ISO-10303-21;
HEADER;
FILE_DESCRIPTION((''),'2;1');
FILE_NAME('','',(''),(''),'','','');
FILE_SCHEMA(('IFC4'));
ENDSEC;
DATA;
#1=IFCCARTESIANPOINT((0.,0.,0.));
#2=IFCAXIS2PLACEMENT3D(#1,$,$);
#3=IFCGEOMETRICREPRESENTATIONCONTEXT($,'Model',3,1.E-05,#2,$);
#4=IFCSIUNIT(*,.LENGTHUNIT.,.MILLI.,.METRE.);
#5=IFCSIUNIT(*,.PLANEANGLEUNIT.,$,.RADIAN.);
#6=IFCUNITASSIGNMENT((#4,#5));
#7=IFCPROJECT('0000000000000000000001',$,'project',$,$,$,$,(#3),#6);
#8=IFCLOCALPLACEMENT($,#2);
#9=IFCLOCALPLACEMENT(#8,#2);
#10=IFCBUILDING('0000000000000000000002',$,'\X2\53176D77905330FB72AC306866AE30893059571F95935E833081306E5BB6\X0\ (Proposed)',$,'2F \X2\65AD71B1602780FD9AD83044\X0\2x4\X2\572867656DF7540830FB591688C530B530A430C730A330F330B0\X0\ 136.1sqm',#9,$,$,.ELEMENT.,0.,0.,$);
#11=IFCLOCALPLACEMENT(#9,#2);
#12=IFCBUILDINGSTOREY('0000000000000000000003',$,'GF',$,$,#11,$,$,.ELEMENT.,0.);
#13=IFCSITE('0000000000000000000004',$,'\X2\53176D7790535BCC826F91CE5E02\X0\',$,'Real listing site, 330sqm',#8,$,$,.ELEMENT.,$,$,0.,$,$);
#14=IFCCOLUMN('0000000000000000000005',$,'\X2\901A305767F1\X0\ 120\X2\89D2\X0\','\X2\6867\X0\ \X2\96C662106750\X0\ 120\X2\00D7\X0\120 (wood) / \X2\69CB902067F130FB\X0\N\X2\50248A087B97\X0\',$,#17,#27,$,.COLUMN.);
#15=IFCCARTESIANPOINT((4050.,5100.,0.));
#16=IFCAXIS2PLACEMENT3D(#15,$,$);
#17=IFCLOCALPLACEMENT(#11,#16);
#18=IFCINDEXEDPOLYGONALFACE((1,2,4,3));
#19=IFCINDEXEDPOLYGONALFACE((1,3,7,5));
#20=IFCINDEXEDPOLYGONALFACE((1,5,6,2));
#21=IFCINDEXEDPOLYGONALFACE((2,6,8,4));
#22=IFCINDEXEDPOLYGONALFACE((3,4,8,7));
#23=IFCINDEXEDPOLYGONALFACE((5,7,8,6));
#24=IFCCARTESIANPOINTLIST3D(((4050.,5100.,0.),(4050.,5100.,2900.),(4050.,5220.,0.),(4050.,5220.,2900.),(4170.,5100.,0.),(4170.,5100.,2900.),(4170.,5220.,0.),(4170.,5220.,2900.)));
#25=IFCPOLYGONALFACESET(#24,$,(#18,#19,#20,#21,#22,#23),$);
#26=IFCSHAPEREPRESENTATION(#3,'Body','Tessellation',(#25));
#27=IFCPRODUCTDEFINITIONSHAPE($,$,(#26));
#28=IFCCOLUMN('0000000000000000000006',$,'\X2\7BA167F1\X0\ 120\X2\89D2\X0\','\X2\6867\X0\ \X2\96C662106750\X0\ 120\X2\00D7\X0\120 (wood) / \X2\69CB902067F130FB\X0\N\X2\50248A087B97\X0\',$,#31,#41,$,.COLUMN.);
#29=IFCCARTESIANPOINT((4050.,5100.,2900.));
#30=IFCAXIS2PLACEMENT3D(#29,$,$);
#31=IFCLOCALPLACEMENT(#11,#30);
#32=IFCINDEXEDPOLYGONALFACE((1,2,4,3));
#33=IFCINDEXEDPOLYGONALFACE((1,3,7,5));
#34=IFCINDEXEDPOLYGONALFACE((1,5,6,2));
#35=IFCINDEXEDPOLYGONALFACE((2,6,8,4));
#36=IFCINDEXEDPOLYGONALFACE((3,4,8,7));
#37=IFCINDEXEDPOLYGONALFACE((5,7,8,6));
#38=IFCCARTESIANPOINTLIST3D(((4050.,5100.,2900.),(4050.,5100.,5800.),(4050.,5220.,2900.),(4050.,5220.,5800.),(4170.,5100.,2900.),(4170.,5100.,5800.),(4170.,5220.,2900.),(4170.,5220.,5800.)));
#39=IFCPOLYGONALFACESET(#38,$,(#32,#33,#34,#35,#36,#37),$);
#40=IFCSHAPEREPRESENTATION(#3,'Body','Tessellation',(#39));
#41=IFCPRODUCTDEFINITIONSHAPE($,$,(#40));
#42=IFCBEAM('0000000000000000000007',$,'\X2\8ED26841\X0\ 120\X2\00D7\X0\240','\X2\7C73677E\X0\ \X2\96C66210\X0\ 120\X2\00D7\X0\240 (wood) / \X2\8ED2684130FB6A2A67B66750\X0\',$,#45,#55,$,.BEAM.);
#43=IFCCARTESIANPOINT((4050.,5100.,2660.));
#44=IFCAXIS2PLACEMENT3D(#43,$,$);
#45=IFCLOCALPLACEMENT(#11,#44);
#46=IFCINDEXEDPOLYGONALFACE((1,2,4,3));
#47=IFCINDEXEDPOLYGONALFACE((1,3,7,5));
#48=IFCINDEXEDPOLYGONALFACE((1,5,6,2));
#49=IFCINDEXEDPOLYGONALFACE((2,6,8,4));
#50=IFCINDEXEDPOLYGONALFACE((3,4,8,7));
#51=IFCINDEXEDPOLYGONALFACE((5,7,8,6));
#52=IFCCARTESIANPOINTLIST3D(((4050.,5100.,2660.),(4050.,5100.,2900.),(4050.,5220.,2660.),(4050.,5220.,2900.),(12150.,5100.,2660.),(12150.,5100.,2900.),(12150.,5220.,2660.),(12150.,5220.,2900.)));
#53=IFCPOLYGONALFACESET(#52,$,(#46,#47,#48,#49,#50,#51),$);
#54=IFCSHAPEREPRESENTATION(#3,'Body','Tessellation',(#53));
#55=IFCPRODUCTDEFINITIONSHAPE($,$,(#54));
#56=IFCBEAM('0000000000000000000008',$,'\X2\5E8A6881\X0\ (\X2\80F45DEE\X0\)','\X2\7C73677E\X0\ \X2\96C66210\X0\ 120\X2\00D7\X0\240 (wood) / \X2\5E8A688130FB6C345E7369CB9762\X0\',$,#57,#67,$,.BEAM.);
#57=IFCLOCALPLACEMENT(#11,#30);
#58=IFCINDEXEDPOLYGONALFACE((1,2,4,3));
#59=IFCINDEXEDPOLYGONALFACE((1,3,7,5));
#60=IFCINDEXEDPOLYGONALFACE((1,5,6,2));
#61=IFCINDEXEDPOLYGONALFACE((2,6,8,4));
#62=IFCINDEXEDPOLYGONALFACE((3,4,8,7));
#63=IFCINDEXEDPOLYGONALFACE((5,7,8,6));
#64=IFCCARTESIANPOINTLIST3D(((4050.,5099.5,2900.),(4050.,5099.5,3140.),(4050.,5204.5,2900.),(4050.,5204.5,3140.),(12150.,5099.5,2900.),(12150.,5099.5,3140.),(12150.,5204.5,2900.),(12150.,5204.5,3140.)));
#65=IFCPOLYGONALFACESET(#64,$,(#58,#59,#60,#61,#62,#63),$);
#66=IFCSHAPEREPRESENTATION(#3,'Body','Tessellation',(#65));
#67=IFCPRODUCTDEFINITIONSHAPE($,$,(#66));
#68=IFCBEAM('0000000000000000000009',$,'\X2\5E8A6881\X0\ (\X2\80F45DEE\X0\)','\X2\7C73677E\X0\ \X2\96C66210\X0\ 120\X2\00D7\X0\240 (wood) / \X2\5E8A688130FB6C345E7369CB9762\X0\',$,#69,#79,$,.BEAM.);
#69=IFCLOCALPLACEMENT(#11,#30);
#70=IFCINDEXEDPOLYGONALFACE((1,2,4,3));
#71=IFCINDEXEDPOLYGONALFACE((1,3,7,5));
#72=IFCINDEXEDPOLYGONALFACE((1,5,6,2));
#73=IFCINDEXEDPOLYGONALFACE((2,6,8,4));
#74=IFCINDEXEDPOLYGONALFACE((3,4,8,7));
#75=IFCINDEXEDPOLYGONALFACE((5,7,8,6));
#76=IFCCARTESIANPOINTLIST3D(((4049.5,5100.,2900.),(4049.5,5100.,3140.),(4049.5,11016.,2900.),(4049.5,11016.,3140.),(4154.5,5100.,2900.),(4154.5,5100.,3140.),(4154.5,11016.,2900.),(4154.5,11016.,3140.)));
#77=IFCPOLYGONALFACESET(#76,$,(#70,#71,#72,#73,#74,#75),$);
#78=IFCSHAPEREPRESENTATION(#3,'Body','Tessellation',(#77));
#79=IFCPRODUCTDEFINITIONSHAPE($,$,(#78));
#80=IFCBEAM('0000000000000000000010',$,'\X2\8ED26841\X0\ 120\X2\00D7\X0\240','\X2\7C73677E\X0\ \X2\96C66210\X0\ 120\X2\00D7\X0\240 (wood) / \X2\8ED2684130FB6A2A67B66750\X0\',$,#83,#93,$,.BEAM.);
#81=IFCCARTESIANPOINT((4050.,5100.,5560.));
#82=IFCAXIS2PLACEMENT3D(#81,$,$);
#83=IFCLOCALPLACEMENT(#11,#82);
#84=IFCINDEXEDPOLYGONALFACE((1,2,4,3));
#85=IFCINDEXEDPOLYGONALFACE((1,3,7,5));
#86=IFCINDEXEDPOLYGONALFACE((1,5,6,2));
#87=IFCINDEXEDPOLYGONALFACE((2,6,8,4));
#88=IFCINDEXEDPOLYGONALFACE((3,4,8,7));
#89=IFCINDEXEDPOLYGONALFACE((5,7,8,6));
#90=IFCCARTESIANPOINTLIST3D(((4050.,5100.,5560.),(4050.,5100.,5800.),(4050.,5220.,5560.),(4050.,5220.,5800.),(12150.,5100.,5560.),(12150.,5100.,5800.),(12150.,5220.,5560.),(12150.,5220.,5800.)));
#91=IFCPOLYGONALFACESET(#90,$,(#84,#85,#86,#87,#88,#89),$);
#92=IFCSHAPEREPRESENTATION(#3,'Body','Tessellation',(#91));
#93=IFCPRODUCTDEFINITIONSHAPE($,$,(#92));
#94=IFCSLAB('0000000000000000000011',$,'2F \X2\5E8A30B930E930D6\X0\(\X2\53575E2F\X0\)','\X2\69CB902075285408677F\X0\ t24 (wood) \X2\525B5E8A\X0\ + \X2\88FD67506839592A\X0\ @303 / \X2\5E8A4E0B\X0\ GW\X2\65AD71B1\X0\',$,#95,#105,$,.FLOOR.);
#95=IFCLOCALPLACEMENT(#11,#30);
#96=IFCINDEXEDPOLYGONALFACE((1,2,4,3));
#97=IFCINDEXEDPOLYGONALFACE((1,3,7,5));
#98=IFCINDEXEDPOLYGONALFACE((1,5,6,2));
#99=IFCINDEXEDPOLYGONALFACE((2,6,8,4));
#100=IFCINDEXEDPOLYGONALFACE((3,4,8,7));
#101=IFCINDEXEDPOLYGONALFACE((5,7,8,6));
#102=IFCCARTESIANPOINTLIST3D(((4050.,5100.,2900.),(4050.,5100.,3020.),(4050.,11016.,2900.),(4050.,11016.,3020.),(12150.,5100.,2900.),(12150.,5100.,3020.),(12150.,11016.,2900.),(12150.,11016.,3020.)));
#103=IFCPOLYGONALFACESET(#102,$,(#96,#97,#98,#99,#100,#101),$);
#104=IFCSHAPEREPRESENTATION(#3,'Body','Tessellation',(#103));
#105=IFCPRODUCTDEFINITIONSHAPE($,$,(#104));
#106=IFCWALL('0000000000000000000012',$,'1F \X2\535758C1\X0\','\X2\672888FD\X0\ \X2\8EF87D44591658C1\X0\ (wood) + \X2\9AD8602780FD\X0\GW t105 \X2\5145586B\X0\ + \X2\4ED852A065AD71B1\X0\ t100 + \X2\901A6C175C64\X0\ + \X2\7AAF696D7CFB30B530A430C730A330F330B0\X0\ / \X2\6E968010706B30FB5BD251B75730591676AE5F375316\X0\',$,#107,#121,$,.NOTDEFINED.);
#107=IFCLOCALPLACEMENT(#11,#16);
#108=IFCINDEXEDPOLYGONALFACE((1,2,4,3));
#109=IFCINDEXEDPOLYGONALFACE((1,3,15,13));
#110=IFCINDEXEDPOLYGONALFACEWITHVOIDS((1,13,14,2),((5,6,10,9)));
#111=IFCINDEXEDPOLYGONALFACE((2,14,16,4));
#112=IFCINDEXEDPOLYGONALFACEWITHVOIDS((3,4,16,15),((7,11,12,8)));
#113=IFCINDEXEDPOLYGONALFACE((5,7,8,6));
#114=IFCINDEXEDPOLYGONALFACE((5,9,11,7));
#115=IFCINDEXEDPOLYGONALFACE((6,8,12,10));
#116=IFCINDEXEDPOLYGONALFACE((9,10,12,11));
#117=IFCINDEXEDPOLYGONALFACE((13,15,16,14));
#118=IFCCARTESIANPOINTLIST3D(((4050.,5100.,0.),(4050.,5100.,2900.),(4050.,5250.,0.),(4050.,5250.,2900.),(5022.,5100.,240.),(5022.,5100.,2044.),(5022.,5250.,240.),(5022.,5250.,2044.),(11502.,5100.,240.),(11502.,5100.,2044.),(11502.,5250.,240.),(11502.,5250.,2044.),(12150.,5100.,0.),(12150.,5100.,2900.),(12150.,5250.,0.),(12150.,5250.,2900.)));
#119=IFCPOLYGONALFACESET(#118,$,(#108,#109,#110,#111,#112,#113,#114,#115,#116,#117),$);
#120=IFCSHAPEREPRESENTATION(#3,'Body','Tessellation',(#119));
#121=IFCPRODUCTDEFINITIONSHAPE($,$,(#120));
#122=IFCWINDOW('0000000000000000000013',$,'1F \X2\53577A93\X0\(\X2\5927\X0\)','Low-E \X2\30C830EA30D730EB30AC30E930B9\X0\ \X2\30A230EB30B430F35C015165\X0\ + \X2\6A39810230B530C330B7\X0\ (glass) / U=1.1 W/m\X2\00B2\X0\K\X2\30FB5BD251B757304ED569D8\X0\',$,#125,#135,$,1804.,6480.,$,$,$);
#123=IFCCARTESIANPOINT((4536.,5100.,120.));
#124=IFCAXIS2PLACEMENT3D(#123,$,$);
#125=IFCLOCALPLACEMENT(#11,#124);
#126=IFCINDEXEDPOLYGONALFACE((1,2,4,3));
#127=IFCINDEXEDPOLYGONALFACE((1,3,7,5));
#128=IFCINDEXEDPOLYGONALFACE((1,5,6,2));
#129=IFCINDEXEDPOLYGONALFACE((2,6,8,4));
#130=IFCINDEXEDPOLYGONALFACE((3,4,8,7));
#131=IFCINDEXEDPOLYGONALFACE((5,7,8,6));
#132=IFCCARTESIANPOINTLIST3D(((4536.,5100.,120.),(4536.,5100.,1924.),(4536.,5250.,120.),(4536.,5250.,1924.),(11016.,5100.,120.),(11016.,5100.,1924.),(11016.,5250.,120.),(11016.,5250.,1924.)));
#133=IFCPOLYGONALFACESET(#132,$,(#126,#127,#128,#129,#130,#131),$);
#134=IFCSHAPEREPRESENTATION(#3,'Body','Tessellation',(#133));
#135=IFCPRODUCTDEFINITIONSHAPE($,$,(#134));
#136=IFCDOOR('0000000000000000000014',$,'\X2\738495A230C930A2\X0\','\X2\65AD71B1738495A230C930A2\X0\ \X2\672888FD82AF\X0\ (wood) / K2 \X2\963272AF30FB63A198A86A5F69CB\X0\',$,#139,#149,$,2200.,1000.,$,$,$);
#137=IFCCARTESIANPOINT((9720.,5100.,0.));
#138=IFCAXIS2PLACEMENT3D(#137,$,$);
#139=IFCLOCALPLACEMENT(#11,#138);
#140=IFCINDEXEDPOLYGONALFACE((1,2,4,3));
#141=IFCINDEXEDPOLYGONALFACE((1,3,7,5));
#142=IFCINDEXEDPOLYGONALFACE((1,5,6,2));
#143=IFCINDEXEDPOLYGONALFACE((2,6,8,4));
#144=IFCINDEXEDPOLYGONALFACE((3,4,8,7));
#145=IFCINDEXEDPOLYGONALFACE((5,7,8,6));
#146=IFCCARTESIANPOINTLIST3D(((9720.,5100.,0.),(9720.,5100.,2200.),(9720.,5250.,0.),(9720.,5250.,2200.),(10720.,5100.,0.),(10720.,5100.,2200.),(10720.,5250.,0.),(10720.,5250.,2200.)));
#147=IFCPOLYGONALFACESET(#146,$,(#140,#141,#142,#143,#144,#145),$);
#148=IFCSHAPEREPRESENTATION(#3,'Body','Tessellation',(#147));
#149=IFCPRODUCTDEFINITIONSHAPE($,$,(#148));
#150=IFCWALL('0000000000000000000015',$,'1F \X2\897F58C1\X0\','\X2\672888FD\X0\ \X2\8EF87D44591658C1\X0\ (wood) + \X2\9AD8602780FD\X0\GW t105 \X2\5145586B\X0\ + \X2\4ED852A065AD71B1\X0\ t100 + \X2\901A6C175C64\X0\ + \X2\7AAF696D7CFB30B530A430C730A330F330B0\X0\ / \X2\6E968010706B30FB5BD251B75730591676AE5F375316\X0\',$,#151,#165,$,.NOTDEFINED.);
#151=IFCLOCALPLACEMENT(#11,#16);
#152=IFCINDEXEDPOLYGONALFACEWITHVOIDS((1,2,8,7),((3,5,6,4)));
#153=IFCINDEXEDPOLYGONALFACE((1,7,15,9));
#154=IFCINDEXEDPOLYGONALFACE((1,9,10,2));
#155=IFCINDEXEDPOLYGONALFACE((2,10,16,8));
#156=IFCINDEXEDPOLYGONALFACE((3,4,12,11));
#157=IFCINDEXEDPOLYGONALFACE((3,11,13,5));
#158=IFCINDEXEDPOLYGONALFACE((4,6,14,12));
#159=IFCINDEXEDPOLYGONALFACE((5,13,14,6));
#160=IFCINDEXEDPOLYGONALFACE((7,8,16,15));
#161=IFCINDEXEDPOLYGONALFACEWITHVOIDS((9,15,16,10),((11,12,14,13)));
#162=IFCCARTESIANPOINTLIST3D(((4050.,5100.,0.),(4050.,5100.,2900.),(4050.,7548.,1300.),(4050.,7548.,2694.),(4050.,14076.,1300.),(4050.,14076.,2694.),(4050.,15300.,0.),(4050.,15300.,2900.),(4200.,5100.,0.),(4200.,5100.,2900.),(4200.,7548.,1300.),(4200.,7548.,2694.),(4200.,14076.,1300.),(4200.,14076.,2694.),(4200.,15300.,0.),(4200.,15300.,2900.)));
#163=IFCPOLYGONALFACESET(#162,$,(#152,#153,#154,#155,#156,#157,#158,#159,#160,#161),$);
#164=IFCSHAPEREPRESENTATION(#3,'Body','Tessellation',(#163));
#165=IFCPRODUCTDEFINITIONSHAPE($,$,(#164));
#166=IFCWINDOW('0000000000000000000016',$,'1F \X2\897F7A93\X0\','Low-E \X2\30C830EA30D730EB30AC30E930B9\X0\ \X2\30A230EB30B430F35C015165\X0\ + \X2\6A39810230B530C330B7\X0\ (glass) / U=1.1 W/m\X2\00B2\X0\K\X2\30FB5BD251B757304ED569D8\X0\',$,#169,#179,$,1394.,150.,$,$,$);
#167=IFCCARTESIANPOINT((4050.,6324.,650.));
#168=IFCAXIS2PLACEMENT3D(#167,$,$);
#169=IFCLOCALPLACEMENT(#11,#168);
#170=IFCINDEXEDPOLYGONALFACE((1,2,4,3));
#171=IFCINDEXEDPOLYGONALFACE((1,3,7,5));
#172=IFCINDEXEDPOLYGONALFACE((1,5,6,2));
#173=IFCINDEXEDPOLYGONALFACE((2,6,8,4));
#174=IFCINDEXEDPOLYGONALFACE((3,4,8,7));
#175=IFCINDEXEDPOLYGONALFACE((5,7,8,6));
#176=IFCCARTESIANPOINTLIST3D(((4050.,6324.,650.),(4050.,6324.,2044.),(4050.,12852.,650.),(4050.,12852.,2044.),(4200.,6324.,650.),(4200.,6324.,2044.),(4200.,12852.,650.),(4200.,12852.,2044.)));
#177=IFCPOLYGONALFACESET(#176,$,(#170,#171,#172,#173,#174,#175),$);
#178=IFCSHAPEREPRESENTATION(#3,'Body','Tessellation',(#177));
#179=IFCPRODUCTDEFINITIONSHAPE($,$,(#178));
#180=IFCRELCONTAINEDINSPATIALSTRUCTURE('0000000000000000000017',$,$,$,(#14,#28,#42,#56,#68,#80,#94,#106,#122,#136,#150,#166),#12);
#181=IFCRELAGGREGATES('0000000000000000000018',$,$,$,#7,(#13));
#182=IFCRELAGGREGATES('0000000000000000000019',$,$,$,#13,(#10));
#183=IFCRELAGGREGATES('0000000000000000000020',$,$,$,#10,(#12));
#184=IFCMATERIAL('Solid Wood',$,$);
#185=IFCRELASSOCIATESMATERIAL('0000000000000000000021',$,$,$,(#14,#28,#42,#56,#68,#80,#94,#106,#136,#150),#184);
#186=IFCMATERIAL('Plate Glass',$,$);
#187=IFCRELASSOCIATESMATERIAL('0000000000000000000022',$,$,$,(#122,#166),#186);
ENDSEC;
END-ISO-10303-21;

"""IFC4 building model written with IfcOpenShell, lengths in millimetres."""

from ifc_helpers import new_model, si_unit, frame, frame_2d, origin, place, context, project, spatial, rectangle, extrude, material, element, fill, save


model = new_model("IFC4")

# Units and contexts
model_context = context("Model", 3, precision=1e-05, world=origin())
ifc_project = project(units=[si_unit("LENGTHUNIT", "METRE", prefix="MILLI"), si_unit("PLANEANGLEUNIT", "RADIAN")], contexts=[model_context])

# Site, building, storey
site_placement = place(None, origin())
site = spatial("IfcSite", under=ifc_project, at=site_placement, Name="北海道富良野市", ObjectType="Real listing site, 330sqm", CompositionType="ELEMENT", RefElevation=0.0)
building_placement = place(site_placement, origin())
building = spatial("IfcBuilding", under=site, at=building_placement, Name="北海道・犬と暮らす土間広めの家 (Proposed)", ObjectType="2F 断熱性能高い2x4在来混合・外装サイディング 136.1sqm", CompositionType="ELEMENT", ElevationOfRefHeight=0.0, ElevationOfTerrain=0.0)
storey_placement = place(building_placement, origin())
storey = spatial("IfcBuildingStorey", under=building, at=storey_placement, Name="GF", CompositionType="ELEMENT", Elevation=0.0)

# Columns
ifc_material_1 = material(Name="Solid Wood")
column_1_placement = place(storey_placement, frame((4050.0, 5100.0, 0.0)))
element("IfcColumn", 1, at=column_1_placement, inside=storey, material=ifc_material_1, Name="通し柱 120角", Description="桧 集成材 120×120 (wood) / 構造柱・N値計算", PredefinedType="COLUMN", context=model_context, shape_type="SweptSolid", body=[
    extrude(rectangle(XDim=120.0, YDim=120.0, at=frame_2d((60.0, 60.0))), frame((4050.0, 5100.0, 0.0)), (0.0, 0.0, 1.0), 2900.0),
])
column_2_placement = place(storey_placement, frame((4050.0, 5100.0, 2900.0)))
element("IfcColumn", 2, at=column_2_placement, inside=storey, material=ifc_material_1, Name="管柱 120角", Description="桧 集成材 120×120 (wood) / 構造柱・N値計算", PredefinedType="COLUMN", context=model_context, shape_type="SweptSolid", body=[
    extrude(rectangle(XDim=120.0, YDim=120.0, at=frame_2d((60.0, 60.0))), frame((4050.0, 5100.0, 2900.0)), (0.0, 0.0, 1.0), 2900.0),
])

# Beams
beam_1_placement = place(storey_placement, frame((4050.0, 5100.0, 2660.0)))
element("IfcBeam", 3, at=beam_1_placement, inside=storey, material=ifc_material_1, Name="軒桁 120×240", Description="米松 集成 120×240 (wood) / 軒桁・横架材", PredefinedType="BEAM", context=model_context, shape_type="SweptSolid", body=[
    extrude(rectangle(XDim=8100.0, YDim=120.0, at=frame_2d((4050.0, 60.0))), frame((4050.0, 5100.0, 2660.0)), (0.0, 0.0, 1.0), 240.0),
])
beam_2_placement = place(storey_placement, frame((4050.0, 5100.0, 2900.0)))
element("IfcBeam", 4, at=beam_2_placement, inside=storey, material=ifc_material_1, Name="床梁 (胴差)", Description="米松 集成 120×240 (wood) / 床梁・水平構面", PredefinedType="BEAM", context=model_context, shape_type="SweptSolid", body=[
    extrude(rectangle(XDim=8100.0, YDim=105.0, at=frame_2d((4050.0, 52.0))), frame((4050.0, 5100.0, 2900.0)), (0.0, 0.0, 1.0), 240.0),
])
beam_3_placement = place(storey_placement, frame((4050.0, 5100.0, 2900.0)))
element("IfcBeam", 5, at=beam_3_placement, inside=storey, material=ifc_material_1, Name="床梁 (胴差)", Description="米松 集成 120×240 (wood) / 床梁・水平構面", PredefinedType="BEAM", context=model_context, shape_type="SweptSolid", body=[
    extrude(rectangle(XDim=105.0, YDim=5916.0, at=frame_2d((52.0, 2958.0))), frame((4050.0, 5100.0, 2900.0)), (0.0, 0.0, 1.0), 240.0),
])
beam_4_placement = place(storey_placement, frame((4050.0, 5100.0, 5560.0)))
element("IfcBeam", 6, at=beam_4_placement, inside=storey, material=ifc_material_1, Name="軒桁 120×240", Description="米松 集成 120×240 (wood) / 軒桁・横架材", PredefinedType="BEAM", context=model_context, shape_type="SweptSolid", body=[
    extrude(rectangle(XDim=8100.0, YDim=120.0, at=frame_2d((4050.0, 60.0))), frame((4050.0, 5100.0, 5560.0)), (0.0, 0.0, 1.0), 240.0),
])

# Slab
slab_1_placement = place(storey_placement, frame((4050.0, 5100.0, 2900.0)))
element("IfcSlab", 7, at=slab_1_placement, inside=storey, material=ifc_material_1, Name="2F 床スラブ(南帯)", Description="構造用合板 t24 (wood) 剛床 + 製材根太 @303 / 床下 GW断熱", PredefinedType="FLOOR", context=model_context, shape_type="SweptSolid", body=[
    extrude(rectangle(XDim=8100.0, YDim=5916.0, at=frame_2d((4050.0, 2958.0))), frame((4050.0, 5100.0, 2900.0)), (0.0, 0.0, 1.0), 120.0),
])

# Wall, openings, window, door
wall_1_placement = place(storey_placement, frame((4050.0, 5100.0, 0.0)))
wall_1 = element("IfcWall", 8, at=wall_1_placement, inside=storey, material=ifc_material_1, Name="1F 南壁", Description="木製 軸組外壁 (wood) + 高性能GW t105 充填 + 付加断熱 t100 + 通気層 + 窯業系サイディング / 準耐火・寒冷地外皮強化", PredefinedType="NOTDEFINED", context=model_context, shape_type="SweptSolid", body=[
    extrude(rectangle(XDim=8100.0, YDim=150.0, at=frame_2d((4050.0, 75.0))), frame((4050.0, 5100.0, 0.0)), (0.0, 0.0, 1.0), 2900.0),
])
opening_1_placement = place(storey_placement, frame((4536.0, 5100.0, 120.0)))
opening_1 = element("IfcOpeningElement", 9, at=opening_1_placement, cuts=wall_1, PredefinedType="NOTDEFINED", context=model_context, shape_type="SweptSolid", body=[
    extrude(rectangle(XDim=6480.0, YDim=150.0, at=frame_2d((3240.0, 75.0))), frame((4536.0, 5100.0, 120.0)), (0.0, 0.0, 1.0), 1804.0),
])
opening_2_placement = place(storey_placement, frame((9720.0, 5100.0, 0.0)))
opening_2 = element("IfcOpeningElement", 10, at=opening_2_placement, cuts=wall_1, PredefinedType="NOTDEFINED", context=model_context, shape_type="SweptSolid", body=[
    extrude(rectangle(XDim=1000.0, YDim=150.0, at=frame_2d((500.0, 75.0))), frame((9720.0, 5100.0, 0.0)), (0.0, 0.0, 1.0), 2200.0),
])
ifc_material_2 = material(Name="Plate Glass")
window_1_placement = place(storey_placement, frame((4536.0, 5100.0, 120.0)))
window_1 = element("IfcWindow", 11, at=window_1_placement, inside=storey, material=ifc_material_2, Name="1F 南窓(大)", Description="Low-E トリプルガラス アルゴン封入 + 樹脂サッシ (glass) / U=1.1 W/m²K・寒冷地仕様", OverallHeight=1804.0, OverallWidth=6480.0, context=model_context, shape_type="SweptSolid", body=[
    extrude(rectangle(XDim=6480.0, YDim=150.0, at=frame_2d((3240.0, 75.0))), frame((4536.0, 5100.0, 120.0)), (0.0, 0.0, 1.0), 1804.0),
])
fill(opening_1, window_1)
door_placement = place(storey_placement, frame((9720.0, 5100.0, 0.0)))
door = element("IfcDoor", 12, at=door_placement, inside=storey, material=ifc_material_1, Name="玄関ドア", Description="断熱玄関ドア 木製芯 (wood) / K2 防犯・採風機構", OverallHeight=2200.0, OverallWidth=1000.0, context=model_context, shape_type="SweptSolid", body=[
    extrude(rectangle(XDim=1000.0, YDim=150.0, at=frame_2d((500.0, 75.0))), frame((9720.0, 5100.0, 0.0)), (0.0, 0.0, 1.0), 2200.0),
])
fill(opening_2, door)

# Wall, opening, window
wall_2_placement = place(storey_placement, frame((4050.0, 5100.0, 0.0)))
wall_2 = element("IfcWall", 13, at=wall_2_placement, inside=storey, material=ifc_material_1, Name="1F 西壁", Description="木製 軸組外壁 (wood) + 高性能GW t105 充填 + 付加断熱 t100 + 通気層 + 窯業系サイディング / 準耐火・寒冷地外皮強化", PredefinedType="NOTDEFINED", context=model_context, shape_type="SweptSolid", body=[
    extrude(rectangle(XDim=150.0, YDim=10200.0, at=frame_2d((75.0, 5100.0))), frame((4050.0, 5100.0, 0.0)), (0.0, 0.0, 1.0), 2900.0),
])
opening_3_placement = place(storey_placement, frame((4050.0, 6324.0, 650.0)))
opening_3 = element("IfcOpeningElement", 14, at=opening_3_placement, cuts=wall_2, PredefinedType="NOTDEFINED", context=model_context, shape_type="SweptSolid", body=[
    extrude(rectangle(XDim=150.0, YDim=6528.0, at=frame_2d((75.0, 3264.0))), frame((4050.0, 6324.0, 650.0)), (0.0, 0.0, 1.0), 1394.0),
])
window_2_placement = place(storey_placement, frame((4050.0, 6324.0, 650.0)))
window_2 = element("IfcWindow", 15, at=window_2_placement, inside=storey, material=ifc_material_2, Name="1F 西窓", Description="Low-E トリプルガラス アルゴン封入 + 樹脂サッシ (glass) / U=1.1 W/m²K・寒冷地仕様", OverallHeight=1394.0, OverallWidth=150.0, context=model_context, shape_type="SweptSolid", body=[
    extrude(rectangle(XDim=150.0, YDim=6528.0, at=frame_2d((75.0, 3264.0))), frame((4050.0, 6324.0, 650.0)), (0.0, 0.0, 1.0), 1394.0),
])
fill(opening_3, window_2)

save(model, "model.ifc")
